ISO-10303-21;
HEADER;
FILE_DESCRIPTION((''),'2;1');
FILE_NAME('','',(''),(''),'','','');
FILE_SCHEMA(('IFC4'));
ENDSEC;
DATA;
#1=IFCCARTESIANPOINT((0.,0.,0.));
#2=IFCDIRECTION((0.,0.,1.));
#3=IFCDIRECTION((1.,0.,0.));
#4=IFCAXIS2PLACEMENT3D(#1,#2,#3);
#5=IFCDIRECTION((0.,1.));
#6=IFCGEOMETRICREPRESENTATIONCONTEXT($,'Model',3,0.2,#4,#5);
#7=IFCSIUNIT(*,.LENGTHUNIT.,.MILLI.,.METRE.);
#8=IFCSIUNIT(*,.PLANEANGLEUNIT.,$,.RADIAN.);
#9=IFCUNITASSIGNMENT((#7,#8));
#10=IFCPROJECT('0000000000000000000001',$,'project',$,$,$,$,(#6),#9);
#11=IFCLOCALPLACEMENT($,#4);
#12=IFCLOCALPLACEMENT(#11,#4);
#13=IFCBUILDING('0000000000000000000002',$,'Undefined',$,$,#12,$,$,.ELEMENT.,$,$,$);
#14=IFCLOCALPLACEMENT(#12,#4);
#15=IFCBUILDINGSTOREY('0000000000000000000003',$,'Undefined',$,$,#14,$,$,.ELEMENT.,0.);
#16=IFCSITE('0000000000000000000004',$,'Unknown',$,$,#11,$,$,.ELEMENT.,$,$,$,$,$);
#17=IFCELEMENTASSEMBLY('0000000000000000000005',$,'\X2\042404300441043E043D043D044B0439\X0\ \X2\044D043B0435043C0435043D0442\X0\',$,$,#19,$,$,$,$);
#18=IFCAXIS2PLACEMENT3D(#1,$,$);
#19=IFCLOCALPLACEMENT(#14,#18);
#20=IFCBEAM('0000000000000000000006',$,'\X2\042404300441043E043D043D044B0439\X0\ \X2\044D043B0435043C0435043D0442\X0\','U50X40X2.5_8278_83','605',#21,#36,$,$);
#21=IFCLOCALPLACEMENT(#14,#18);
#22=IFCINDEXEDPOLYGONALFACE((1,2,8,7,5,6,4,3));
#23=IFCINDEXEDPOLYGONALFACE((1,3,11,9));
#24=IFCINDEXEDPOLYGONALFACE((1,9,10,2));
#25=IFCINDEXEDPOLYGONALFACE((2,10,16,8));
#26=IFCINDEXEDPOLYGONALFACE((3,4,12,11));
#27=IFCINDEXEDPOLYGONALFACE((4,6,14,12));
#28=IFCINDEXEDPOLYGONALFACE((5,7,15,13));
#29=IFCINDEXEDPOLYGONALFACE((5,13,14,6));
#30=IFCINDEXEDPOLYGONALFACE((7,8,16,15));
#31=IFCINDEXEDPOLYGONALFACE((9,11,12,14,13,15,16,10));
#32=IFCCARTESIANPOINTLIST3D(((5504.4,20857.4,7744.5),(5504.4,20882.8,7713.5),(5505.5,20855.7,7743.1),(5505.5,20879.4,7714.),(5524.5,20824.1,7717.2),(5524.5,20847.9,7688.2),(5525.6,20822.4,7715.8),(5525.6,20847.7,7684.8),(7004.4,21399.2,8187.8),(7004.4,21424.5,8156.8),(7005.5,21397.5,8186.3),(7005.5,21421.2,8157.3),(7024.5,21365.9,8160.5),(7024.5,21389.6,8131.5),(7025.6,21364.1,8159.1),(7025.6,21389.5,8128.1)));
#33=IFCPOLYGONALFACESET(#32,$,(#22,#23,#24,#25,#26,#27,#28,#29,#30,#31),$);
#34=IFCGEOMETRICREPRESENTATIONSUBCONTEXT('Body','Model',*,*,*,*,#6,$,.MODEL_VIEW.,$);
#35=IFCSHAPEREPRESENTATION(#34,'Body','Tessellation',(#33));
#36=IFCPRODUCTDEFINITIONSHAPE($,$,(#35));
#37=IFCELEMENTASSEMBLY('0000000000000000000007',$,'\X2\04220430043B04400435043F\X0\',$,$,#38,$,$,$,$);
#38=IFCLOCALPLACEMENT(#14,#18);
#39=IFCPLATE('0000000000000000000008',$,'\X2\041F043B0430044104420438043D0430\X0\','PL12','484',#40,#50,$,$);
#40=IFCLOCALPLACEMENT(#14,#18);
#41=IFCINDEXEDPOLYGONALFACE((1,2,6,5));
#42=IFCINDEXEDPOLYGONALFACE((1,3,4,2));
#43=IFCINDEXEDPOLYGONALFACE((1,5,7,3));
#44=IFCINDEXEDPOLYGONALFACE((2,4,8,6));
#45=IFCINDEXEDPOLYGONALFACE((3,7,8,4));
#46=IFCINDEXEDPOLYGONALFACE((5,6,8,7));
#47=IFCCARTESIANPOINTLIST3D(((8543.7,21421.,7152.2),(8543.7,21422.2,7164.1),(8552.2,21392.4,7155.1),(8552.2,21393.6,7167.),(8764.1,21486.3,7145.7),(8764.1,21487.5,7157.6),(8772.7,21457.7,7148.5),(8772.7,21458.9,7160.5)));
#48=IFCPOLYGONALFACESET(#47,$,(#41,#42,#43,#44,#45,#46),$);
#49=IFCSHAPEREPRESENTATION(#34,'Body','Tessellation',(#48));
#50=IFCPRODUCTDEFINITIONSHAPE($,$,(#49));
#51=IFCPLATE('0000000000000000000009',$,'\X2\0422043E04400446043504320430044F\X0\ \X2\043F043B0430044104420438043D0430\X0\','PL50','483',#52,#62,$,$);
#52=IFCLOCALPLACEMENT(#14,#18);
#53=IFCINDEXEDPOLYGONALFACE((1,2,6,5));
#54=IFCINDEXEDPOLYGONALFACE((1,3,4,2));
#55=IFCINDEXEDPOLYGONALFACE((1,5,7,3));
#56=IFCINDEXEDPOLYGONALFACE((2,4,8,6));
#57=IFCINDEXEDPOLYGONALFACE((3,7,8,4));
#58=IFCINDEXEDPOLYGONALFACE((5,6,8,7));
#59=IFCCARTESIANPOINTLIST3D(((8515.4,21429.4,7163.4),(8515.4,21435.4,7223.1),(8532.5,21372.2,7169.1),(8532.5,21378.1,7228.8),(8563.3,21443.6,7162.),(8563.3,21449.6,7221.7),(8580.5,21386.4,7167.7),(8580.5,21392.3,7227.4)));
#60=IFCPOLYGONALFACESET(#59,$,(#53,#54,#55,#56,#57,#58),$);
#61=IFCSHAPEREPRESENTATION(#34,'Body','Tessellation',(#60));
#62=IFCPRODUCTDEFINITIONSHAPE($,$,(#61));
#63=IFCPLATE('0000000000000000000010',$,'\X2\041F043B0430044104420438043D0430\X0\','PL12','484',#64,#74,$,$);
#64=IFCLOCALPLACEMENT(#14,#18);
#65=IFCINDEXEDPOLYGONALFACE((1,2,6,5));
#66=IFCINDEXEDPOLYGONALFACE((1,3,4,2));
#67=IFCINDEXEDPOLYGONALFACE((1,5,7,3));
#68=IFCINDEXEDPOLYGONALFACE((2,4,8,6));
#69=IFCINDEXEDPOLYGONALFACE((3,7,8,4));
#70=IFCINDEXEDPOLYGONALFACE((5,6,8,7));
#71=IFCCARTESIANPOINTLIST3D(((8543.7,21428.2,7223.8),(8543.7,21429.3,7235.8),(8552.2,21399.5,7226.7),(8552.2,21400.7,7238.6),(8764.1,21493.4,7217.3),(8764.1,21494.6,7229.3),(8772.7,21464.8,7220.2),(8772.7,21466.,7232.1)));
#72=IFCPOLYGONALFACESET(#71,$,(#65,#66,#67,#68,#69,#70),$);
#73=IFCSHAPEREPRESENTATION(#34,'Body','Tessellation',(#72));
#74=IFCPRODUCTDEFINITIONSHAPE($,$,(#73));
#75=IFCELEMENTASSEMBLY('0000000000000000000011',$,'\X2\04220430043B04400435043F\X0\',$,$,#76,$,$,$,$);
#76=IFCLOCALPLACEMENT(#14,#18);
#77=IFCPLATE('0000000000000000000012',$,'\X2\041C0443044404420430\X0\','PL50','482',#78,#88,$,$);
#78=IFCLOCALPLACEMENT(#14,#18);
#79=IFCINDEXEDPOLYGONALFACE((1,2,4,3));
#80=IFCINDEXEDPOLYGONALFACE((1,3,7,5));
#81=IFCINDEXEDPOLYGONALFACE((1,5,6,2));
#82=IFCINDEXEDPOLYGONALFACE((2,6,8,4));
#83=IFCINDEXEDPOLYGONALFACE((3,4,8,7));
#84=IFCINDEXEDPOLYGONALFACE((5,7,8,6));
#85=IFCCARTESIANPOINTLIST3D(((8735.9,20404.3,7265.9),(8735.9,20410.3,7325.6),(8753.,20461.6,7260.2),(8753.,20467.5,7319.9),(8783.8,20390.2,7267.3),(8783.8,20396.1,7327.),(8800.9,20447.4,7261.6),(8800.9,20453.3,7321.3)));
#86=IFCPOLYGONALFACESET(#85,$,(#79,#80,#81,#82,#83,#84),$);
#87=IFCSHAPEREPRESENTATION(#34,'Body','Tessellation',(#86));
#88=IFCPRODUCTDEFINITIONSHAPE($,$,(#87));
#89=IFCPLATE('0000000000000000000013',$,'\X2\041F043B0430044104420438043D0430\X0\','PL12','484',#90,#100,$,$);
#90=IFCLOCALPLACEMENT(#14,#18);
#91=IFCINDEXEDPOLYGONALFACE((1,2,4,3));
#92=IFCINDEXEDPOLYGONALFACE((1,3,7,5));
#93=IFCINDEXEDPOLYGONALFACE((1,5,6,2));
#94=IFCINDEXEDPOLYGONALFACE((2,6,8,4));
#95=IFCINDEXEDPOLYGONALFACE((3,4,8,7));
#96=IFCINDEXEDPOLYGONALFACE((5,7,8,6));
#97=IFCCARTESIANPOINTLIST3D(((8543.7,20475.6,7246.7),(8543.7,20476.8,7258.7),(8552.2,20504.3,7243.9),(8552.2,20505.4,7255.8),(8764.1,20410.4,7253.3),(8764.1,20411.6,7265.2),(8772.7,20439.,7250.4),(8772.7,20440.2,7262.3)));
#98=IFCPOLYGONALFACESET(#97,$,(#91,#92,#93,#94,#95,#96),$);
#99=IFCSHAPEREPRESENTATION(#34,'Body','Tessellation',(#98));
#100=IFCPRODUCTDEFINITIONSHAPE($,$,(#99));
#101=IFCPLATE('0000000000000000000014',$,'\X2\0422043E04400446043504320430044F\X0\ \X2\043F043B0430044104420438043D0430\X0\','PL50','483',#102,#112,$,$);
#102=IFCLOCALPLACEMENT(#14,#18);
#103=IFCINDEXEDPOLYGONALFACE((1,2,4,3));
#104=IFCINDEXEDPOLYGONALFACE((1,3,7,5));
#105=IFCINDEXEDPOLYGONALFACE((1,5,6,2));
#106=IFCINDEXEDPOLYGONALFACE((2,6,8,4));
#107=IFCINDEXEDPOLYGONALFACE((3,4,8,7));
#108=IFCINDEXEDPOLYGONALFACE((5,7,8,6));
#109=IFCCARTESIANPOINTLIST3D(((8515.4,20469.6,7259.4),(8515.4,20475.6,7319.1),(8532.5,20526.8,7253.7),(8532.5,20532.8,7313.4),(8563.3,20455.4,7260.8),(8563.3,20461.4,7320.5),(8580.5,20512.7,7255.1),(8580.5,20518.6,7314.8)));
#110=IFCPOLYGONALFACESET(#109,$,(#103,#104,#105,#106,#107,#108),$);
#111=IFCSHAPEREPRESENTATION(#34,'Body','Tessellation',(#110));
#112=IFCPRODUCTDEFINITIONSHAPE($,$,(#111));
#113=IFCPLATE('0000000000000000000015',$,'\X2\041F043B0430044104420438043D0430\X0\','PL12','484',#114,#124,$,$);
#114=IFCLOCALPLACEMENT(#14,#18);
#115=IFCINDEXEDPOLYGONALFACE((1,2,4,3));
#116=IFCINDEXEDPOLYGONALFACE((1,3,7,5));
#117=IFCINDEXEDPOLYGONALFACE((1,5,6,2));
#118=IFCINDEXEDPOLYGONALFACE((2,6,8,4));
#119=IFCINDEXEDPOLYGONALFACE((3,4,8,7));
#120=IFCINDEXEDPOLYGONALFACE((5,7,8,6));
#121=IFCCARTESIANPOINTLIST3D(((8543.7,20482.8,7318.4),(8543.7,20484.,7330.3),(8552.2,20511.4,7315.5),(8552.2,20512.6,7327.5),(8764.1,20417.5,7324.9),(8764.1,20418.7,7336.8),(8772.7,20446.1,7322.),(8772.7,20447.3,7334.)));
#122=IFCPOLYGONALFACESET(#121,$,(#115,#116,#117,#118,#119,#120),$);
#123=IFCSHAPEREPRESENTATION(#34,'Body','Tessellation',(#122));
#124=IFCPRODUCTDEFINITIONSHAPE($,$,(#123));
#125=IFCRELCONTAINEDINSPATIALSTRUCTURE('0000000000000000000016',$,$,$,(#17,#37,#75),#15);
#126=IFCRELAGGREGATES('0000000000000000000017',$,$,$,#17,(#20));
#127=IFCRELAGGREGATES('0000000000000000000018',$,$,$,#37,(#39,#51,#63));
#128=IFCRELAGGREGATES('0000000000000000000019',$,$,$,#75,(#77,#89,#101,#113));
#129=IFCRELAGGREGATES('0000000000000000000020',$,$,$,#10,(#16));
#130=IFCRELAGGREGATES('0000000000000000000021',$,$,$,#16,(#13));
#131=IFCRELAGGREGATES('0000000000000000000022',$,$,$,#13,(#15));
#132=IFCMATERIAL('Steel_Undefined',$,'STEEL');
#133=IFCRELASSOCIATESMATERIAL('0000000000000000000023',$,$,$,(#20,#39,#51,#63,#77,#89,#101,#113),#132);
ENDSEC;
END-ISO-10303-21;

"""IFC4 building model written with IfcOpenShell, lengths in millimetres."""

from ifc_helpers import new_model, si_unit, direction, frame, origin_with_axes, place, context, subcontext, project, spatial, line, indexed_curve, outline, extrude, material, element, aggregate, save


model = new_model("IFC4")

# Units and contexts
model_context = context("Model", 3, precision=0.2, world=origin_with_axes(), true_north=direction((0.0, 1.0)))
body_context = subcontext(model_context, "Body", "Model", "MODEL_VIEW")
ifc_project = project(units=[si_unit("LENGTHUNIT", "METRE", prefix="MILLI"), si_unit("PLANEANGLEUNIT", "RADIAN")], contexts=[model_context])

# Site, building, storey
site_placement = place(None, origin_with_axes())
site = spatial("IfcSite", under=ifc_project, at=site_placement, Name="Unknown", CompositionType="ELEMENT")
building_placement = place(site_placement, origin_with_axes())
building = spatial("IfcBuilding", under=site, at=building_placement, Name="Undefined", CompositionType="ELEMENT")
storey_placement = place(building_placement, origin_with_axes())
storey = spatial("IfcBuildingStorey", under=building, at=storey_placement, Name="Undefined", CompositionType="ELEMENT", Elevation=0.0)

# Shared definitions
ifc_material_1 = material(Name="Steel_Undefined", Category="STEEL")

# Element assembly, beam
assembly_1_placement = place(storey_placement, frame((7015.0, 21394.3, 8157.9), z_axis=(0.0, -0.633238, 0.773957), x_axis=(-0.906183, -0.327295, -0.267787)))
assembly_1 = element("IfcElementAssembly", 1, at=assembly_1_placement, inside=storey, Name="Фасонный элемент")
beam_1_placement = place(assembly_1_placement, origin_with_axes())
beam_1 = element("IfcBeam", 2, at=beam_1_placement, material=ifc_material_1, Name="Фасонный элемент", Description="U50X40X2.5_8278_83", ObjectType="605", context=body_context, shape_type="SolidModel", body=[
    extrude(outline(indexed_curve([(-20.0, -25.0), (20.0, -25.0), (20.0, -22.5), (-17.5, -22.5), (-17.5, 22.5), (20.0, 22.5), (20.0, 25.0), (-20.0, 25.0)], segments=[line(1, 2, 3, 4, 5, 6, 7, 8, 1)])), frame((0.0, 0.0, 0.0), z_axis=(-1.0, 0.0, 0.0), x_axis=(0.0, 0.0, 1.0)), (0.0, 0.0, -1.0), 1655.3),
])
aggregate(assembly_1, [beam_1])

# Element assemblies, plates
assembly_2_placement = place(storey_placement, frame((8776.9, 21450.5, 7221.6), z_axis=(-0.958459, -0.283816, 0.028382), x_axis=(-0.285231, 0.953702, -0.09537)))
assembly_2 = element("IfcElementAssembly", 3, at=assembly_2_placement, inside=storey, Name="Талреп")
plate_1_placement = place(assembly_2_placement, frame((15.0, 66.0, 230.0), z_axis=(0.0, 1.0, 0.0), x_axis=(1.0, 0.0, 0.0)))
plate_1 = element("IfcPlate", 4, at=plate_1_placement, material=ifc_material_1, Name="Пластина", Description="PL12", ObjectType="484", context=body_context, shape_type="SolidModel", body=[
    extrude(outline(indexed_curve([(0.0, 0.0), (30.0, 0.0), (30.0, 230.0), (0.0, 230.0)], segments=[line(1, 2, 3, 4, 1)])), frame((0.0, 0.0, 6.0), z_axis=(0.0, 0.0, 1.0), x_axis=(1.0, 0.0, 0.0)), (0.0, 0.0, -1.0), 12.0),
])
plate_2_placement = place(assembly_2_placement, frame((0.0, 0.0, 230.0), z_axis=(0.0, 0.0, 1.0), x_axis=(1.0, 0.0, 0.0)))
plate_2 = element("IfcPlate", 5, at=plate_2_placement, material=ifc_material_1, Name="Торцевая пластина", Description="PL50", ObjectType="483", context=body_context, shape_type="SolidModel", body=[
    extrude(outline(indexed_curve([(0.0, 0.0), (60.0, 0.0), (60.0, 60.0), (0.0, 60.0)], segments=[line(1, 2, 3, 4, 1)])), frame((0.0, 0.0, 25.0), z_axis=(0.0, 0.0, 1.0), x_axis=(1.0, 0.0, 0.0)), (0.0, 0.0, -1.0), 50.0),
])
plate_3_placement = place(assembly_2_placement, frame((15.0, -6.0, 230.0), z_axis=(0.0, 1.0, 0.0), x_axis=(1.0, 0.0, 0.0)))
plate_3 = element("IfcPlate", 6, at=plate_3_placement, material=ifc_material_1, Name="Пластина", Description="PL12", ObjectType="484", context=body_context, shape_type="SolidModel", body=[
    extrude(outline(indexed_curve([(0.0, 0.0), (30.0, 0.0), (30.0, 230.0), (0.0, 230.0)], segments=[line(1, 2, 3, 4, 1)])), frame((0.0, 0.0, 6.0), z_axis=(0.0, 0.0, 1.0), x_axis=(1.0, 0.0, 0.0)), (0.0, 0.0, -1.0), 12.0),
])
assembly_3_placement = place(storey_placement, frame((8759.8, 20403.2, 7326.3), z_axis=(-0.958459, 0.283816, -0.028382), x_axis=(0.285231, 0.953702, -0.09537)))
assembly_3 = element("IfcElementAssembly", 7, at=assembly_3_placement, inside=storey, Name="Талреп")
plate_4_placement = place(assembly_3_placement, origin_with_axes())
plate_4 = element("IfcPlate", 8, at=plate_4_placement, material=ifc_material_1, Name="Муфта", Description="PL50", ObjectType="482", context=body_context, shape_type="SolidModel", body=[
    extrude(outline(indexed_curve([(0.0, 0.0), (60.0, 0.0), (60.0, 60.0), (0.0, 60.0)], segments=[line(1, 2, 3, 4, 1)])), frame((0.0, 0.0, 25.0), z_axis=(0.0, 0.0, 1.0), x_axis=(1.0, 0.0, 0.0)), (0.0, 0.0, -1.0), 50.0),
])
plate_5_placement = place(assembly_3_placement, frame((15.0, 66.0, 230.0), z_axis=(0.0, 1.0, 0.0), x_axis=(1.0, 0.0, 0.0)))
plate_5 = element("IfcPlate", 9, at=plate_5_placement, material=ifc_material_1, Name="Пластина", Description="PL12", ObjectType="484", context=body_context, shape_type="SolidModel", body=[
    extrude(outline(indexed_curve([(0.0, 0.0), (30.0, 0.0), (30.0, 230.0), (0.0, 230.0)], segments=[line(1, 2, 3, 4, 1)])), frame((0.0, 0.0, 6.0), z_axis=(0.0, 0.0, 1.0), x_axis=(1.0, 0.0, 0.0)), (0.0, 0.0, -1.0), 12.0),
])
plate_6_placement = place(assembly_3_placement, frame((0.0, 0.0, 230.0), z_axis=(0.0, 0.0, 1.0), x_axis=(1.0, 0.0, 0.0)))
plate_6 = element("IfcPlate", 10, at=plate_6_placement, material=ifc_material_1, Name="Торцевая пластина", Description="PL50", ObjectType="483", context=body_context, shape_type="SolidModel", body=[
    extrude(outline(indexed_curve([(0.0, 0.0), (60.0, 0.0), (60.0, 60.0), (0.0, 60.0)], segments=[line(1, 2, 3, 4, 1)])), frame((0.0, 0.0, 25.0), z_axis=(0.0, 0.0, 1.0), x_axis=(1.0, 0.0, 0.0)), (0.0, 0.0, -1.0), 50.0),
])
plate_7_placement = place(assembly_3_placement, frame((15.0, -6.0, 230.0), z_axis=(0.0, 1.0, 0.0), x_axis=(1.0, 0.0, 0.0)))
plate_7 = element("IfcPlate", 11, at=plate_7_placement, material=ifc_material_1, Name="Пластина", Description="PL12", ObjectType="484", context=body_context, shape_type="SolidModel", body=[
    extrude(outline(indexed_curve([(0.0, 0.0), (30.0, 0.0), (30.0, 230.0), (0.0, 230.0)], segments=[line(1, 2, 3, 4, 1)])), frame((0.0, 0.0, 6.0), z_axis=(0.0, 0.0, 1.0), x_axis=(1.0, 0.0, 0.0)), (0.0, 0.0, -1.0), 12.0),
])

aggregate(assembly_2, [plate_1, plate_2, plate_3])
aggregate(assembly_3, [plate_4, plate_5, plate_6, plate_7])

save(model, "model.ifc")
